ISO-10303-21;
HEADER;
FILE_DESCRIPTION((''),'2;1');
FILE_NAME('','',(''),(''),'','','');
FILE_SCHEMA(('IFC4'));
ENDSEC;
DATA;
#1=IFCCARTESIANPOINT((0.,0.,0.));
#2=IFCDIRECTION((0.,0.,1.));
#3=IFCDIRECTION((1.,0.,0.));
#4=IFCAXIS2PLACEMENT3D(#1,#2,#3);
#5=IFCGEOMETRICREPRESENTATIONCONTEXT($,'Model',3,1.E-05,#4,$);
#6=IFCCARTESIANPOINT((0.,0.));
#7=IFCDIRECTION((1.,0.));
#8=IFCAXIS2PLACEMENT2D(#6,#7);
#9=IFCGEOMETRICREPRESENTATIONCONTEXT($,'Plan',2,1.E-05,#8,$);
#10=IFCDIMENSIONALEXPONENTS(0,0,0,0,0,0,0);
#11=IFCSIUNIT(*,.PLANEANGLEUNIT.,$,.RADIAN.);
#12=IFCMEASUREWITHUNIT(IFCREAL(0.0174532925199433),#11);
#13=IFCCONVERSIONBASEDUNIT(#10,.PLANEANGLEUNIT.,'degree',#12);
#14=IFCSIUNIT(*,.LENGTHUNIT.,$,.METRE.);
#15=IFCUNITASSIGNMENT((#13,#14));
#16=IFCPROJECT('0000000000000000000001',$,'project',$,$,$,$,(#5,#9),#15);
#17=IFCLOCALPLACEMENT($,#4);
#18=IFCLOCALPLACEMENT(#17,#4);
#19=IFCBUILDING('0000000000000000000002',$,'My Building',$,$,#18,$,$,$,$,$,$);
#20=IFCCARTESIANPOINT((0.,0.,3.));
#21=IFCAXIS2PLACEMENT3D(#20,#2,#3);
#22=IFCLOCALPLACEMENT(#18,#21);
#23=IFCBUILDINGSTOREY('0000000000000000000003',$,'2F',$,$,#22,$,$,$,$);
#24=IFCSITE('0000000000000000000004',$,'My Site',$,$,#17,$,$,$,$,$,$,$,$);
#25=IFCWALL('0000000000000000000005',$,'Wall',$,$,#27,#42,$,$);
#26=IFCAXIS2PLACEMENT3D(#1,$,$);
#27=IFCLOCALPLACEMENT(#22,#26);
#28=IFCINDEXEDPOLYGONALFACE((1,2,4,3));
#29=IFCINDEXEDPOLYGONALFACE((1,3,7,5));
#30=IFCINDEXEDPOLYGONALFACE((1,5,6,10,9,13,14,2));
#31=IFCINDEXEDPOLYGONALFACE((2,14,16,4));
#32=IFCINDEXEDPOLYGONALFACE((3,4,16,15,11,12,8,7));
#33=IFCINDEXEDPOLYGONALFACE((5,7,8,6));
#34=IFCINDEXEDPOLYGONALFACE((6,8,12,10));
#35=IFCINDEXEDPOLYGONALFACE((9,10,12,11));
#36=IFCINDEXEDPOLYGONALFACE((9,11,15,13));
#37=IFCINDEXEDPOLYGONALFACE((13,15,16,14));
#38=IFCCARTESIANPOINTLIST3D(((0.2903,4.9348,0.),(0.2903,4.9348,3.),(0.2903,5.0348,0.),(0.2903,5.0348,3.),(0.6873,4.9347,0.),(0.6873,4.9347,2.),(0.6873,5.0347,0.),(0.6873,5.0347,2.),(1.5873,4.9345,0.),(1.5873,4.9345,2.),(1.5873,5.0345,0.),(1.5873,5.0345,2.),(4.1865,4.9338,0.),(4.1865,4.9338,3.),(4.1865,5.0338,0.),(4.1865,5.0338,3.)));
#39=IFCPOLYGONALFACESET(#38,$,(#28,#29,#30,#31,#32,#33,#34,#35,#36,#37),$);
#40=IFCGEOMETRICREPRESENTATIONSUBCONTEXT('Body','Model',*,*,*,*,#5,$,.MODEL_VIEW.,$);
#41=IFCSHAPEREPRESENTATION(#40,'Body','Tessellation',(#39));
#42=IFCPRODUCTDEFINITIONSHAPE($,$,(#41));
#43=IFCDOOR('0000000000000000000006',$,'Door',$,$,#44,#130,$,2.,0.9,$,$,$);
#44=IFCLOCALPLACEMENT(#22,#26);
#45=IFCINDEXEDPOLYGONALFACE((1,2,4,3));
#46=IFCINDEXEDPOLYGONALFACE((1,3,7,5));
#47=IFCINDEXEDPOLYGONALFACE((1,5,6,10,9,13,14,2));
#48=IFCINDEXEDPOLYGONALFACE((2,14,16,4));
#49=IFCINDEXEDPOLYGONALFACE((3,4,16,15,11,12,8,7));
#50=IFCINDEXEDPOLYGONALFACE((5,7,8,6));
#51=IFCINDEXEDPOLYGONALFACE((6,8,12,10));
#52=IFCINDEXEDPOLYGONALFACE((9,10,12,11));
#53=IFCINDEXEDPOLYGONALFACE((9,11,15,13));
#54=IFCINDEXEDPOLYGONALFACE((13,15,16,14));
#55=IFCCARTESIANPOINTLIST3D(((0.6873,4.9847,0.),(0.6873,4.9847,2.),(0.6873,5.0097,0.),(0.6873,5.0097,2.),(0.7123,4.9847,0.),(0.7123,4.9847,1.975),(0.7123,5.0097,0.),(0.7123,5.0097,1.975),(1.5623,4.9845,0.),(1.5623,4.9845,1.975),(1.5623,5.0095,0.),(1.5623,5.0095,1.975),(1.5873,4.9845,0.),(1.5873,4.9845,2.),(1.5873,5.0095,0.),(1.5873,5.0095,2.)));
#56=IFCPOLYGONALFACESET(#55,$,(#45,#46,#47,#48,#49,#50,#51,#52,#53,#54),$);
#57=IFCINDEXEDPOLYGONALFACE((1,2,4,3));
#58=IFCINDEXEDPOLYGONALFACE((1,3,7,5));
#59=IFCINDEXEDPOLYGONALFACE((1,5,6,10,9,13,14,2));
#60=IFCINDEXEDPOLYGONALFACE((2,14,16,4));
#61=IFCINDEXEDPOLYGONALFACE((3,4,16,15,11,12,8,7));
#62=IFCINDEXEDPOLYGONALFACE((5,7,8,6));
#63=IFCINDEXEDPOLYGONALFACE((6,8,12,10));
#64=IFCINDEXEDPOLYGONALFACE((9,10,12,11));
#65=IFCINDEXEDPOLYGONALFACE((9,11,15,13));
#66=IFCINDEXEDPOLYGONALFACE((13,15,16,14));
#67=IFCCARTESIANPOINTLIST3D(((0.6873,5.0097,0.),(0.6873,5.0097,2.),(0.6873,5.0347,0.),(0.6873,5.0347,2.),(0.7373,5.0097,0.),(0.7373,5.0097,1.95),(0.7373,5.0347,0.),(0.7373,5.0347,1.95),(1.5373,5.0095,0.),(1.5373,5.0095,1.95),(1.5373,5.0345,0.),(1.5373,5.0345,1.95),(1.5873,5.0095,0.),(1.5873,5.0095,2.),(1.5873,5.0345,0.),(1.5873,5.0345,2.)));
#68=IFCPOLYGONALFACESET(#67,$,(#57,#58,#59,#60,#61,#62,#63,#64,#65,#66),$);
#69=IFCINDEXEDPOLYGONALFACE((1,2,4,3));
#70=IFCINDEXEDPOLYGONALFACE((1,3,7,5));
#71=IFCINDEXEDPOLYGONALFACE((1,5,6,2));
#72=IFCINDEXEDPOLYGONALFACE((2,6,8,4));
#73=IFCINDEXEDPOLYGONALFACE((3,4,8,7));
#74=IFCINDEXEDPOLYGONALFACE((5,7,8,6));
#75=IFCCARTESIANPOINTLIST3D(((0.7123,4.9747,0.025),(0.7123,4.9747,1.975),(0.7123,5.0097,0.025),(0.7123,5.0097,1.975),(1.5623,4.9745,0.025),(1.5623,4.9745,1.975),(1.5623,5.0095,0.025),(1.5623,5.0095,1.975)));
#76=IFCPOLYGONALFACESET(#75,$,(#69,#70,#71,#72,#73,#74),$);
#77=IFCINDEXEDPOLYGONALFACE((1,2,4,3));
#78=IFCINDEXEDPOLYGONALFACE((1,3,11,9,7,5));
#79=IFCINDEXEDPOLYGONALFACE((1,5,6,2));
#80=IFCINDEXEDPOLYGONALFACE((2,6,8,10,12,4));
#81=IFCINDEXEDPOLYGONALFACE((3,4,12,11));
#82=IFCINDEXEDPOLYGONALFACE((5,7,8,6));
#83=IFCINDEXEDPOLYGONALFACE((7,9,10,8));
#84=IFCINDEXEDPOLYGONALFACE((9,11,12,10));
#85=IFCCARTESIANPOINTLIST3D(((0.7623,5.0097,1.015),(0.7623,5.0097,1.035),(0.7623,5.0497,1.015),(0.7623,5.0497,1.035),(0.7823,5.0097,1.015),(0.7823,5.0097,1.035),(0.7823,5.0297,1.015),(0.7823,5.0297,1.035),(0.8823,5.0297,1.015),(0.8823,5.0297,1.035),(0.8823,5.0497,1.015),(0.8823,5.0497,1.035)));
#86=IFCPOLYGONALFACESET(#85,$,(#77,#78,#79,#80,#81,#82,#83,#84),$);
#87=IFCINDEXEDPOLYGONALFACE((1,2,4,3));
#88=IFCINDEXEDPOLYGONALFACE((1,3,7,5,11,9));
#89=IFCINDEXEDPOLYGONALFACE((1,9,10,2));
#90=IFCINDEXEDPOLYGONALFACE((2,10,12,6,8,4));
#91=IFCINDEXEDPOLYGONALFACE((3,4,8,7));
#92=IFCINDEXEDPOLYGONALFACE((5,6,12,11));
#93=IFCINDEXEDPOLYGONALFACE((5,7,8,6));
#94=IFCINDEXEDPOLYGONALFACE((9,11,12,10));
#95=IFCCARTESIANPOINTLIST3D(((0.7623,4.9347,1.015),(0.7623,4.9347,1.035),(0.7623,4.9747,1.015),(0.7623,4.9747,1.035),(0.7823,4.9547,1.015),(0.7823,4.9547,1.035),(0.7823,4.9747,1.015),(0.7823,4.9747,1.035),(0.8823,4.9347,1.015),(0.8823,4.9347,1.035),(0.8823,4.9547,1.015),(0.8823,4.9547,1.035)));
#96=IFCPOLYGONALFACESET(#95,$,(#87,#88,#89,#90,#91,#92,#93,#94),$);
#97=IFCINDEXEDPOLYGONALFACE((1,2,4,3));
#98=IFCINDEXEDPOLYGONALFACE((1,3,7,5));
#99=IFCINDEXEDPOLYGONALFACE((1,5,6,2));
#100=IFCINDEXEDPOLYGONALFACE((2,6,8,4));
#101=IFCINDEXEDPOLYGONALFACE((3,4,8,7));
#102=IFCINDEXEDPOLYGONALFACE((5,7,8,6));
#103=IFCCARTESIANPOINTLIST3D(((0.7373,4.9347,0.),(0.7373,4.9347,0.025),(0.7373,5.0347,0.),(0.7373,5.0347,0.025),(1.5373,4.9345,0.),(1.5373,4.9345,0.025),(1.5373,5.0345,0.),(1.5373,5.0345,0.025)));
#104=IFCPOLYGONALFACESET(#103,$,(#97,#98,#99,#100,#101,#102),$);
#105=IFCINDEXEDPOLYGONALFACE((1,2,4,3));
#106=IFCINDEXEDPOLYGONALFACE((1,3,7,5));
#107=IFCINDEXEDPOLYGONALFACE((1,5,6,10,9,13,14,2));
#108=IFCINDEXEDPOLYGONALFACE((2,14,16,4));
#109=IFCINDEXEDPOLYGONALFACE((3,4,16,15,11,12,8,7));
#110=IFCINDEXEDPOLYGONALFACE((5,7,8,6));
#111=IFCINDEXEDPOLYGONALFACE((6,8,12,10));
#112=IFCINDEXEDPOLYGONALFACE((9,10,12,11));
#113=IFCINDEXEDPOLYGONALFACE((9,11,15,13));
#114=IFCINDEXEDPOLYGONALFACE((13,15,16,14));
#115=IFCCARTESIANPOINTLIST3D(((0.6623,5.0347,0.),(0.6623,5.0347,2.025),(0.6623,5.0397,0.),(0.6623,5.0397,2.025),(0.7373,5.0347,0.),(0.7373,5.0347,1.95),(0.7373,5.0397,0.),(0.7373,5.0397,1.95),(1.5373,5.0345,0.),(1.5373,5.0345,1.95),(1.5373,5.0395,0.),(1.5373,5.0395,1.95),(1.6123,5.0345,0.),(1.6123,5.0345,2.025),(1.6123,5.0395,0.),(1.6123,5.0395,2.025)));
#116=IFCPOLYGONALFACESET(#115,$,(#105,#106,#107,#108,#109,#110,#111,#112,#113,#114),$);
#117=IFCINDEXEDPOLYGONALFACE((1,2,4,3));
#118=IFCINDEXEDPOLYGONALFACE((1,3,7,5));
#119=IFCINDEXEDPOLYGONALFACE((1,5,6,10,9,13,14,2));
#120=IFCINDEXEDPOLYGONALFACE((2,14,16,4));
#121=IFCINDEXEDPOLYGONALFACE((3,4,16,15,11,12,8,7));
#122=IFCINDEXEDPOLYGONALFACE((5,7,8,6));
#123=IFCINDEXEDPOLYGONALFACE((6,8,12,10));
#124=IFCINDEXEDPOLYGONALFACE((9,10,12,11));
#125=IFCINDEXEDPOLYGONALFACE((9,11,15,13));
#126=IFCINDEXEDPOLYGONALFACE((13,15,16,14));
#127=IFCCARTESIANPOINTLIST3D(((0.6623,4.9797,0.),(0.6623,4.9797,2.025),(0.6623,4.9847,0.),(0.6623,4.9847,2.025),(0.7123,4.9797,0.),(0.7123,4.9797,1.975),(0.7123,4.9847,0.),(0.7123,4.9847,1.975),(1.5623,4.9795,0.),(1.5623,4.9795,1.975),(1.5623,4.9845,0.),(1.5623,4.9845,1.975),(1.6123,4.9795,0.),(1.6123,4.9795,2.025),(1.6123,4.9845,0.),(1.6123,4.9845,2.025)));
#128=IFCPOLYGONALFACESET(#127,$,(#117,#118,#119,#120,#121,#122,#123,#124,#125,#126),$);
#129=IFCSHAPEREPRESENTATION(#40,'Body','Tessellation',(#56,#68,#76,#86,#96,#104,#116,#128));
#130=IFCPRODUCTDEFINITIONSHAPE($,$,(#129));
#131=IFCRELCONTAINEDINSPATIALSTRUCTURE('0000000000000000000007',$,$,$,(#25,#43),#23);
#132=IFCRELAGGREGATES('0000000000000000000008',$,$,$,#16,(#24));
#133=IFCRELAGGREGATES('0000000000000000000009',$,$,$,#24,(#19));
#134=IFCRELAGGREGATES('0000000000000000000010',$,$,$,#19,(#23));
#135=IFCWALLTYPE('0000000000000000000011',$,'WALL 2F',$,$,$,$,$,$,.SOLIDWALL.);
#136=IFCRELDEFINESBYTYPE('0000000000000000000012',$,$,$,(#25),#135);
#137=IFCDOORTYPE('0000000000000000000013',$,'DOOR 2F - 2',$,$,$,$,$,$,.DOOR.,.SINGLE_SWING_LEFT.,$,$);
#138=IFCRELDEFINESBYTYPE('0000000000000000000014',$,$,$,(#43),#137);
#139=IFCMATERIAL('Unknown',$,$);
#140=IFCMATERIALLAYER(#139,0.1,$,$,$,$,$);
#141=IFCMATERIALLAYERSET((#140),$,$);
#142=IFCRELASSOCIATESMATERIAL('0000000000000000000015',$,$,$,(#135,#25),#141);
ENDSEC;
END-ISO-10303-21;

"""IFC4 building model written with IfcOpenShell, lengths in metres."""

from ifc_helpers import new_model, entity, si_unit, converted_unit, frame, origin_with_axes, origin_2d_with_axis, place, context, subcontext, project, spatial, line, indexed_curve, outline, extrude, shape, source, transform, mapped, material, layer, layer_set, layer_usage, type_object, type_shapes, element, fill, save


model = new_model("IFC4")

# Units and contexts
model_context = context("Model", 3, precision=1e-05, world=origin_with_axes())
plan_context = context("Plan", 2, precision=1e-05, world=origin_2d_with_axis())
body_context_1 = subcontext(model_context, "Body", "Model", "MODEL_VIEW")
body_context_2 = subcontext(plan_context, "Body", "Plan", "PLAN_VIEW")
ifc_project = project(units=[converted_unit("PLANEANGLEUNIT", "degree", entity("IfcReal", 0.0174532925199433), si_unit("PLANEANGLEUNIT", "RADIAN"), dimensions=[0, 0, 0, 0, 0, 0, 0]), si_unit("LENGTHUNIT", "METRE")], contexts=[model_context, plan_context])

# Site, building, storey
site_placement = place(None, origin_with_axes())
site = spatial("IfcSite", under=ifc_project, at=site_placement, Name="My Site")
building_placement = place(site_placement, origin_with_axes())
building = spatial("IfcBuilding", under=site, at=building_placement, Name="My Building")
storey_placement = place(building_placement, frame((0.0, 0.0, 3.0), z_axis=(0.0, 0.0, 1.0), x_axis=(1.0, 0.0, 0.0)))
storey = spatial("IfcBuildingStorey", under=building, at=storey_placement, Name="2F")

# Shared definitions
ifc_material = material(Name="Unknown")

# Shared definitions
ifc_layer_1 = layer(ifc_material, 0.1)
ifc_layer_set_1 = layer_set([ifc_layer_1])
wall_type = type_object("IfcWallType", Name="WALL 2F", PredefinedType="SOLIDWALL", material=ifc_layer_set_1)

# Wall, opening, door
shared_shape_1 = source(origin_with_axes(), body_context_1, "Body", "SweptSolid", [
    extrude(outline(indexed_curve([(0.0, 0.0), (0.9, 0.0), (0.9, 2.0), (0.0, 2.0)], segments=[line(1, 2, 3, 4, 1)])), frame((0.0, -0.6, 0.0), z_axis=(0.0, -1.0, 0.0), x_axis=(1.0, 0.0, 0.0)), (0.0, 0.0, -1.0), 1.2),
])
door_type = type_object("IfcDoorType", Name="DOOR 2F - 2", OperationType="SINGLE_SWING_LEFT", PredefinedType="DOOR")
shared_shape_2 = source(origin_with_axes(), body_context_1, "Body", "SweptSolid", [
    extrude(outline(indexed_curve([(0.0, 0.0), (0.0, 2.0), (0.9, 2.0), (0.9, 0.0), (0.875, 0.0), (0.875, 1.975), (0.025, 1.975), (0.025, 0.0)], segments=[line(1, 2, 3, 4, 5, 6, 7, 8, 1)])), frame((0.0, 0.025, 0.0), z_axis=(0.0, -1.0, 0.0), x_axis=(1.0, 0.0, 0.0)), (0.0, 0.0, -1.0), 0.025),
    extrude(outline(indexed_curve([(0.0, 0.0), (0.0, 2.0), (0.9, 2.0), (0.9, 0.0), (0.85, 0.0), (0.85, 1.95), (0.05, 1.95), (0.05, 0.0)], segments=[line(1, 2, 3, 4, 5, 6, 7, 8, 1)])), frame((0.0, 0.0, 0.0), z_axis=(0.0, -1.0, 0.0), x_axis=(1.0, 0.0, 0.0)), (0.0, 0.0, -1.0), 0.025),
    extrude(outline(indexed_curve([(0.0, 0.0), (0.85, 0.0), (0.85, 0.035), (0.0, 0.035)], segments=[line(1, 2, 3, 4, 1)])), frame((0.025, 0.025, 0.025), z_axis=(0.0, 0.0, 1.0), x_axis=(1.0, 0.0, 0.0)), (0.0, 0.0, 1.0), 1.95),
    extrude(outline(indexed_curve([(0.0, 0.0), (0.0, -0.04), (-0.12, -0.04), (-0.12, -0.02), (-0.02, -0.02), (-0.02, 0.0)], segments=[line(1, 2, 3, 4, 5, 6, 1)])), frame((0.825, 0.025, 1.015), z_axis=(0.0, 0.0, 1.0), x_axis=(1.0, 0.0, 0.0)), (0.0, 0.0, 1.0), 0.02),
    extrude(outline(indexed_curve([(0.0, 0.0), (0.0, 0.04), (-0.12, 0.04), (-0.12, 0.02), (-0.02, 0.02), (-0.02, 0.0)], segments=[line(1, 2, 3, 4, 5, 6, 1)])), frame((0.825, 0.06, 1.015), z_axis=(0.0, 0.0, 1.0), x_axis=(1.0, 0.0, 0.0)), (0.0, 0.0, 1.0), 0.02),
    extrude(outline(indexed_curve([(0.0, 0.0), (0.8, 0.0), (0.8, 0.1), (0.0, 0.1)], segments=[line(1, 2, 3, 4, 1)])), frame((0.05, 0.0, 0.0), z_axis=(0.0, 0.0, 1.0), x_axis=(1.0, 0.0, 0.0)), (0.0, 0.0, 1.0), 0.025),
    extrude(outline(indexed_curve([(0.0, 0.0), (0.0, 2.025), (0.95, 2.025), (0.95, 0.0), (0.875, 0.0), (0.875, 1.95), (0.075, 1.95), (0.075, 0.0)], segments=[line(1, 2, 3, 4, 5, 6, 7, 8, 1)])), frame((-0.025, -0.005, 0.0), z_axis=(0.0, -1.0, 0.0), x_axis=(1.0, 0.0, 0.0)), (0.0, 0.0, -1.0), 0.005),
    extrude(outline(indexed_curve([(0.0, 0.0), (0.0, 2.025), (0.95, 2.025), (0.95, 0.0), (0.9, 0.0), (0.9, 1.975), (0.05, 1.975), (0.05, 0.0)], segments=[line(1, 2, 3, 4, 5, 6, 7, 8, 1)])), frame((-0.025, 0.05, 0.0), z_axis=(0.0, -1.0, 0.0), x_axis=(1.0, 0.0, 0.0)), (0.0, 0.0, -1.0), 0.005),
])
shared_shape_3 = source(origin_with_axes(), body_context_2, "Body", "Curve2D", [
    entity("IfcIndexedPolyCurve", entity("IfcCartesianPointList2D", [[0.0, 0.0], [0.0, 0.05], [0.025, 0.05], [0.025, 0.025], [0.05, 0.025], [0.05, 0.0]]), [entity("IfcLineIndex", [1, 2, 3, 4, 5, 6, 1])]),
    entity("IfcIndexedPolyCurve", entity("IfcCartesianPointList2D", [[0.9, 0.0], [0.9, 0.05], [0.875, 0.05], [0.875, 0.025], [0.85, 0.025], [0.85, 0.0]]), [entity("IfcLineIndex", [1, 2, 3, 4, 5, 6, 1])]),
    entity("IfcTrimmedCurve", entity("IfcEllipse", entity("IfcAxis2Placement2D", entity("IfcCartesianPoint", [0.06, 0.05]), entity("IfcDirection", [1.0, 0.0])), 0.815, 0.85), [entity("IfcCartesianPoint", [0.875, 0.05])], [entity("IfcCartesianPoint", [0.06, 0.9])], True, "CARTESIAN"),
    entity("IfcIndexedPolyCurve", entity("IfcCartesianPointList2D", [[0.025, 0.05], [0.06, 0.05], [0.06, 0.9], [0.025, 0.9]]), [entity("IfcLineIndex", [1, 2, 3, 4, 1])]),
])
type_shapes(door_type, [shared_shape_2, shared_shape_3])
ifc_layer_usage_1 = layer_usage(ifc_layer_set_1, "AXIS2", "POSITIVE", 0.0)
wall_1_placement = place(storey_placement, frame((4.1865, 5.0338, 0.0), z_axis=(0.0, 0.0, 1.0), x_axis=(-1.0, 0.000249, 0.0)))
wall_1 = element("IfcWall", 1, at=wall_1_placement, inside=storey, type_object=wall_type, material=ifc_layer_usage_1, Name="Wall", context=body_context_1, shape_type="SweptSolid", body=[
    extrude(outline(indexed_curve([(0.0, 0.0), (0.0, 0.1), (3.8962, 0.1), (3.8962, 0.0)], segments=[line(1, 2, 3, 4, 1)])), origin_with_axes(), (0.0, 0.0, 1.0), 3.0),
])
opening_1_placement = place(wall_1_placement, frame((2.5992, 0.0, 0.0), z_axis=(0.0, 0.0, 1.0), x_axis=(1.0, 0.0, 0.0)))
opening_1 = element("IfcOpeningElement", 2, at=opening_1_placement, cuts=wall_1, PredefinedType="OPENING", context=body_context_1, shape_type="MappedRepresentation", body=[
    mapped(shared_shape_1, transform((0.0, 0.0, 0.0), x_axis=(1.0, 0.0, 0.0), y_axis=(0.0, 1.0, 0.0), z_axis=(0.0, 0.0, 1.0), scale=1.0)),
])
door_1_placement = place(opening_1_placement, frame((0.0, 0.0, 0.0), z_axis=(0.0, 0.0, 1.0), x_axis=(1.0, 0.0, 0.0)))
door_1 = element("IfcDoor", 3, at=door_1_placement, inside=storey, type_object=door_type, Name="Door", OverallHeight=2.0, OverallWidth=0.9, shapes=[
    shape(body_context_1, "Body", "MappedRepresentation", [mapped(shared_shape_2, transform((0.0, 0.0, 0.0), x_axis=(1.0, 0.0, 0.0), y_axis=(0.0, 1.0, 0.0), z_axis=(0.0, 0.0, 1.0), scale=1.0))]),
    shape(body_context_2, "Body", "MappedRepresentation", [mapped(shared_shape_3, transform((0.0, 0.0, 0.0), x_axis=(1.0, 0.0, 0.0), y_axis=(0.0, 1.0, 0.0), z_axis=(0.0, 0.0, 1.0), scale=1.0))]),
])
fill(opening_1, door_1)

save(model, "model.ifc")
